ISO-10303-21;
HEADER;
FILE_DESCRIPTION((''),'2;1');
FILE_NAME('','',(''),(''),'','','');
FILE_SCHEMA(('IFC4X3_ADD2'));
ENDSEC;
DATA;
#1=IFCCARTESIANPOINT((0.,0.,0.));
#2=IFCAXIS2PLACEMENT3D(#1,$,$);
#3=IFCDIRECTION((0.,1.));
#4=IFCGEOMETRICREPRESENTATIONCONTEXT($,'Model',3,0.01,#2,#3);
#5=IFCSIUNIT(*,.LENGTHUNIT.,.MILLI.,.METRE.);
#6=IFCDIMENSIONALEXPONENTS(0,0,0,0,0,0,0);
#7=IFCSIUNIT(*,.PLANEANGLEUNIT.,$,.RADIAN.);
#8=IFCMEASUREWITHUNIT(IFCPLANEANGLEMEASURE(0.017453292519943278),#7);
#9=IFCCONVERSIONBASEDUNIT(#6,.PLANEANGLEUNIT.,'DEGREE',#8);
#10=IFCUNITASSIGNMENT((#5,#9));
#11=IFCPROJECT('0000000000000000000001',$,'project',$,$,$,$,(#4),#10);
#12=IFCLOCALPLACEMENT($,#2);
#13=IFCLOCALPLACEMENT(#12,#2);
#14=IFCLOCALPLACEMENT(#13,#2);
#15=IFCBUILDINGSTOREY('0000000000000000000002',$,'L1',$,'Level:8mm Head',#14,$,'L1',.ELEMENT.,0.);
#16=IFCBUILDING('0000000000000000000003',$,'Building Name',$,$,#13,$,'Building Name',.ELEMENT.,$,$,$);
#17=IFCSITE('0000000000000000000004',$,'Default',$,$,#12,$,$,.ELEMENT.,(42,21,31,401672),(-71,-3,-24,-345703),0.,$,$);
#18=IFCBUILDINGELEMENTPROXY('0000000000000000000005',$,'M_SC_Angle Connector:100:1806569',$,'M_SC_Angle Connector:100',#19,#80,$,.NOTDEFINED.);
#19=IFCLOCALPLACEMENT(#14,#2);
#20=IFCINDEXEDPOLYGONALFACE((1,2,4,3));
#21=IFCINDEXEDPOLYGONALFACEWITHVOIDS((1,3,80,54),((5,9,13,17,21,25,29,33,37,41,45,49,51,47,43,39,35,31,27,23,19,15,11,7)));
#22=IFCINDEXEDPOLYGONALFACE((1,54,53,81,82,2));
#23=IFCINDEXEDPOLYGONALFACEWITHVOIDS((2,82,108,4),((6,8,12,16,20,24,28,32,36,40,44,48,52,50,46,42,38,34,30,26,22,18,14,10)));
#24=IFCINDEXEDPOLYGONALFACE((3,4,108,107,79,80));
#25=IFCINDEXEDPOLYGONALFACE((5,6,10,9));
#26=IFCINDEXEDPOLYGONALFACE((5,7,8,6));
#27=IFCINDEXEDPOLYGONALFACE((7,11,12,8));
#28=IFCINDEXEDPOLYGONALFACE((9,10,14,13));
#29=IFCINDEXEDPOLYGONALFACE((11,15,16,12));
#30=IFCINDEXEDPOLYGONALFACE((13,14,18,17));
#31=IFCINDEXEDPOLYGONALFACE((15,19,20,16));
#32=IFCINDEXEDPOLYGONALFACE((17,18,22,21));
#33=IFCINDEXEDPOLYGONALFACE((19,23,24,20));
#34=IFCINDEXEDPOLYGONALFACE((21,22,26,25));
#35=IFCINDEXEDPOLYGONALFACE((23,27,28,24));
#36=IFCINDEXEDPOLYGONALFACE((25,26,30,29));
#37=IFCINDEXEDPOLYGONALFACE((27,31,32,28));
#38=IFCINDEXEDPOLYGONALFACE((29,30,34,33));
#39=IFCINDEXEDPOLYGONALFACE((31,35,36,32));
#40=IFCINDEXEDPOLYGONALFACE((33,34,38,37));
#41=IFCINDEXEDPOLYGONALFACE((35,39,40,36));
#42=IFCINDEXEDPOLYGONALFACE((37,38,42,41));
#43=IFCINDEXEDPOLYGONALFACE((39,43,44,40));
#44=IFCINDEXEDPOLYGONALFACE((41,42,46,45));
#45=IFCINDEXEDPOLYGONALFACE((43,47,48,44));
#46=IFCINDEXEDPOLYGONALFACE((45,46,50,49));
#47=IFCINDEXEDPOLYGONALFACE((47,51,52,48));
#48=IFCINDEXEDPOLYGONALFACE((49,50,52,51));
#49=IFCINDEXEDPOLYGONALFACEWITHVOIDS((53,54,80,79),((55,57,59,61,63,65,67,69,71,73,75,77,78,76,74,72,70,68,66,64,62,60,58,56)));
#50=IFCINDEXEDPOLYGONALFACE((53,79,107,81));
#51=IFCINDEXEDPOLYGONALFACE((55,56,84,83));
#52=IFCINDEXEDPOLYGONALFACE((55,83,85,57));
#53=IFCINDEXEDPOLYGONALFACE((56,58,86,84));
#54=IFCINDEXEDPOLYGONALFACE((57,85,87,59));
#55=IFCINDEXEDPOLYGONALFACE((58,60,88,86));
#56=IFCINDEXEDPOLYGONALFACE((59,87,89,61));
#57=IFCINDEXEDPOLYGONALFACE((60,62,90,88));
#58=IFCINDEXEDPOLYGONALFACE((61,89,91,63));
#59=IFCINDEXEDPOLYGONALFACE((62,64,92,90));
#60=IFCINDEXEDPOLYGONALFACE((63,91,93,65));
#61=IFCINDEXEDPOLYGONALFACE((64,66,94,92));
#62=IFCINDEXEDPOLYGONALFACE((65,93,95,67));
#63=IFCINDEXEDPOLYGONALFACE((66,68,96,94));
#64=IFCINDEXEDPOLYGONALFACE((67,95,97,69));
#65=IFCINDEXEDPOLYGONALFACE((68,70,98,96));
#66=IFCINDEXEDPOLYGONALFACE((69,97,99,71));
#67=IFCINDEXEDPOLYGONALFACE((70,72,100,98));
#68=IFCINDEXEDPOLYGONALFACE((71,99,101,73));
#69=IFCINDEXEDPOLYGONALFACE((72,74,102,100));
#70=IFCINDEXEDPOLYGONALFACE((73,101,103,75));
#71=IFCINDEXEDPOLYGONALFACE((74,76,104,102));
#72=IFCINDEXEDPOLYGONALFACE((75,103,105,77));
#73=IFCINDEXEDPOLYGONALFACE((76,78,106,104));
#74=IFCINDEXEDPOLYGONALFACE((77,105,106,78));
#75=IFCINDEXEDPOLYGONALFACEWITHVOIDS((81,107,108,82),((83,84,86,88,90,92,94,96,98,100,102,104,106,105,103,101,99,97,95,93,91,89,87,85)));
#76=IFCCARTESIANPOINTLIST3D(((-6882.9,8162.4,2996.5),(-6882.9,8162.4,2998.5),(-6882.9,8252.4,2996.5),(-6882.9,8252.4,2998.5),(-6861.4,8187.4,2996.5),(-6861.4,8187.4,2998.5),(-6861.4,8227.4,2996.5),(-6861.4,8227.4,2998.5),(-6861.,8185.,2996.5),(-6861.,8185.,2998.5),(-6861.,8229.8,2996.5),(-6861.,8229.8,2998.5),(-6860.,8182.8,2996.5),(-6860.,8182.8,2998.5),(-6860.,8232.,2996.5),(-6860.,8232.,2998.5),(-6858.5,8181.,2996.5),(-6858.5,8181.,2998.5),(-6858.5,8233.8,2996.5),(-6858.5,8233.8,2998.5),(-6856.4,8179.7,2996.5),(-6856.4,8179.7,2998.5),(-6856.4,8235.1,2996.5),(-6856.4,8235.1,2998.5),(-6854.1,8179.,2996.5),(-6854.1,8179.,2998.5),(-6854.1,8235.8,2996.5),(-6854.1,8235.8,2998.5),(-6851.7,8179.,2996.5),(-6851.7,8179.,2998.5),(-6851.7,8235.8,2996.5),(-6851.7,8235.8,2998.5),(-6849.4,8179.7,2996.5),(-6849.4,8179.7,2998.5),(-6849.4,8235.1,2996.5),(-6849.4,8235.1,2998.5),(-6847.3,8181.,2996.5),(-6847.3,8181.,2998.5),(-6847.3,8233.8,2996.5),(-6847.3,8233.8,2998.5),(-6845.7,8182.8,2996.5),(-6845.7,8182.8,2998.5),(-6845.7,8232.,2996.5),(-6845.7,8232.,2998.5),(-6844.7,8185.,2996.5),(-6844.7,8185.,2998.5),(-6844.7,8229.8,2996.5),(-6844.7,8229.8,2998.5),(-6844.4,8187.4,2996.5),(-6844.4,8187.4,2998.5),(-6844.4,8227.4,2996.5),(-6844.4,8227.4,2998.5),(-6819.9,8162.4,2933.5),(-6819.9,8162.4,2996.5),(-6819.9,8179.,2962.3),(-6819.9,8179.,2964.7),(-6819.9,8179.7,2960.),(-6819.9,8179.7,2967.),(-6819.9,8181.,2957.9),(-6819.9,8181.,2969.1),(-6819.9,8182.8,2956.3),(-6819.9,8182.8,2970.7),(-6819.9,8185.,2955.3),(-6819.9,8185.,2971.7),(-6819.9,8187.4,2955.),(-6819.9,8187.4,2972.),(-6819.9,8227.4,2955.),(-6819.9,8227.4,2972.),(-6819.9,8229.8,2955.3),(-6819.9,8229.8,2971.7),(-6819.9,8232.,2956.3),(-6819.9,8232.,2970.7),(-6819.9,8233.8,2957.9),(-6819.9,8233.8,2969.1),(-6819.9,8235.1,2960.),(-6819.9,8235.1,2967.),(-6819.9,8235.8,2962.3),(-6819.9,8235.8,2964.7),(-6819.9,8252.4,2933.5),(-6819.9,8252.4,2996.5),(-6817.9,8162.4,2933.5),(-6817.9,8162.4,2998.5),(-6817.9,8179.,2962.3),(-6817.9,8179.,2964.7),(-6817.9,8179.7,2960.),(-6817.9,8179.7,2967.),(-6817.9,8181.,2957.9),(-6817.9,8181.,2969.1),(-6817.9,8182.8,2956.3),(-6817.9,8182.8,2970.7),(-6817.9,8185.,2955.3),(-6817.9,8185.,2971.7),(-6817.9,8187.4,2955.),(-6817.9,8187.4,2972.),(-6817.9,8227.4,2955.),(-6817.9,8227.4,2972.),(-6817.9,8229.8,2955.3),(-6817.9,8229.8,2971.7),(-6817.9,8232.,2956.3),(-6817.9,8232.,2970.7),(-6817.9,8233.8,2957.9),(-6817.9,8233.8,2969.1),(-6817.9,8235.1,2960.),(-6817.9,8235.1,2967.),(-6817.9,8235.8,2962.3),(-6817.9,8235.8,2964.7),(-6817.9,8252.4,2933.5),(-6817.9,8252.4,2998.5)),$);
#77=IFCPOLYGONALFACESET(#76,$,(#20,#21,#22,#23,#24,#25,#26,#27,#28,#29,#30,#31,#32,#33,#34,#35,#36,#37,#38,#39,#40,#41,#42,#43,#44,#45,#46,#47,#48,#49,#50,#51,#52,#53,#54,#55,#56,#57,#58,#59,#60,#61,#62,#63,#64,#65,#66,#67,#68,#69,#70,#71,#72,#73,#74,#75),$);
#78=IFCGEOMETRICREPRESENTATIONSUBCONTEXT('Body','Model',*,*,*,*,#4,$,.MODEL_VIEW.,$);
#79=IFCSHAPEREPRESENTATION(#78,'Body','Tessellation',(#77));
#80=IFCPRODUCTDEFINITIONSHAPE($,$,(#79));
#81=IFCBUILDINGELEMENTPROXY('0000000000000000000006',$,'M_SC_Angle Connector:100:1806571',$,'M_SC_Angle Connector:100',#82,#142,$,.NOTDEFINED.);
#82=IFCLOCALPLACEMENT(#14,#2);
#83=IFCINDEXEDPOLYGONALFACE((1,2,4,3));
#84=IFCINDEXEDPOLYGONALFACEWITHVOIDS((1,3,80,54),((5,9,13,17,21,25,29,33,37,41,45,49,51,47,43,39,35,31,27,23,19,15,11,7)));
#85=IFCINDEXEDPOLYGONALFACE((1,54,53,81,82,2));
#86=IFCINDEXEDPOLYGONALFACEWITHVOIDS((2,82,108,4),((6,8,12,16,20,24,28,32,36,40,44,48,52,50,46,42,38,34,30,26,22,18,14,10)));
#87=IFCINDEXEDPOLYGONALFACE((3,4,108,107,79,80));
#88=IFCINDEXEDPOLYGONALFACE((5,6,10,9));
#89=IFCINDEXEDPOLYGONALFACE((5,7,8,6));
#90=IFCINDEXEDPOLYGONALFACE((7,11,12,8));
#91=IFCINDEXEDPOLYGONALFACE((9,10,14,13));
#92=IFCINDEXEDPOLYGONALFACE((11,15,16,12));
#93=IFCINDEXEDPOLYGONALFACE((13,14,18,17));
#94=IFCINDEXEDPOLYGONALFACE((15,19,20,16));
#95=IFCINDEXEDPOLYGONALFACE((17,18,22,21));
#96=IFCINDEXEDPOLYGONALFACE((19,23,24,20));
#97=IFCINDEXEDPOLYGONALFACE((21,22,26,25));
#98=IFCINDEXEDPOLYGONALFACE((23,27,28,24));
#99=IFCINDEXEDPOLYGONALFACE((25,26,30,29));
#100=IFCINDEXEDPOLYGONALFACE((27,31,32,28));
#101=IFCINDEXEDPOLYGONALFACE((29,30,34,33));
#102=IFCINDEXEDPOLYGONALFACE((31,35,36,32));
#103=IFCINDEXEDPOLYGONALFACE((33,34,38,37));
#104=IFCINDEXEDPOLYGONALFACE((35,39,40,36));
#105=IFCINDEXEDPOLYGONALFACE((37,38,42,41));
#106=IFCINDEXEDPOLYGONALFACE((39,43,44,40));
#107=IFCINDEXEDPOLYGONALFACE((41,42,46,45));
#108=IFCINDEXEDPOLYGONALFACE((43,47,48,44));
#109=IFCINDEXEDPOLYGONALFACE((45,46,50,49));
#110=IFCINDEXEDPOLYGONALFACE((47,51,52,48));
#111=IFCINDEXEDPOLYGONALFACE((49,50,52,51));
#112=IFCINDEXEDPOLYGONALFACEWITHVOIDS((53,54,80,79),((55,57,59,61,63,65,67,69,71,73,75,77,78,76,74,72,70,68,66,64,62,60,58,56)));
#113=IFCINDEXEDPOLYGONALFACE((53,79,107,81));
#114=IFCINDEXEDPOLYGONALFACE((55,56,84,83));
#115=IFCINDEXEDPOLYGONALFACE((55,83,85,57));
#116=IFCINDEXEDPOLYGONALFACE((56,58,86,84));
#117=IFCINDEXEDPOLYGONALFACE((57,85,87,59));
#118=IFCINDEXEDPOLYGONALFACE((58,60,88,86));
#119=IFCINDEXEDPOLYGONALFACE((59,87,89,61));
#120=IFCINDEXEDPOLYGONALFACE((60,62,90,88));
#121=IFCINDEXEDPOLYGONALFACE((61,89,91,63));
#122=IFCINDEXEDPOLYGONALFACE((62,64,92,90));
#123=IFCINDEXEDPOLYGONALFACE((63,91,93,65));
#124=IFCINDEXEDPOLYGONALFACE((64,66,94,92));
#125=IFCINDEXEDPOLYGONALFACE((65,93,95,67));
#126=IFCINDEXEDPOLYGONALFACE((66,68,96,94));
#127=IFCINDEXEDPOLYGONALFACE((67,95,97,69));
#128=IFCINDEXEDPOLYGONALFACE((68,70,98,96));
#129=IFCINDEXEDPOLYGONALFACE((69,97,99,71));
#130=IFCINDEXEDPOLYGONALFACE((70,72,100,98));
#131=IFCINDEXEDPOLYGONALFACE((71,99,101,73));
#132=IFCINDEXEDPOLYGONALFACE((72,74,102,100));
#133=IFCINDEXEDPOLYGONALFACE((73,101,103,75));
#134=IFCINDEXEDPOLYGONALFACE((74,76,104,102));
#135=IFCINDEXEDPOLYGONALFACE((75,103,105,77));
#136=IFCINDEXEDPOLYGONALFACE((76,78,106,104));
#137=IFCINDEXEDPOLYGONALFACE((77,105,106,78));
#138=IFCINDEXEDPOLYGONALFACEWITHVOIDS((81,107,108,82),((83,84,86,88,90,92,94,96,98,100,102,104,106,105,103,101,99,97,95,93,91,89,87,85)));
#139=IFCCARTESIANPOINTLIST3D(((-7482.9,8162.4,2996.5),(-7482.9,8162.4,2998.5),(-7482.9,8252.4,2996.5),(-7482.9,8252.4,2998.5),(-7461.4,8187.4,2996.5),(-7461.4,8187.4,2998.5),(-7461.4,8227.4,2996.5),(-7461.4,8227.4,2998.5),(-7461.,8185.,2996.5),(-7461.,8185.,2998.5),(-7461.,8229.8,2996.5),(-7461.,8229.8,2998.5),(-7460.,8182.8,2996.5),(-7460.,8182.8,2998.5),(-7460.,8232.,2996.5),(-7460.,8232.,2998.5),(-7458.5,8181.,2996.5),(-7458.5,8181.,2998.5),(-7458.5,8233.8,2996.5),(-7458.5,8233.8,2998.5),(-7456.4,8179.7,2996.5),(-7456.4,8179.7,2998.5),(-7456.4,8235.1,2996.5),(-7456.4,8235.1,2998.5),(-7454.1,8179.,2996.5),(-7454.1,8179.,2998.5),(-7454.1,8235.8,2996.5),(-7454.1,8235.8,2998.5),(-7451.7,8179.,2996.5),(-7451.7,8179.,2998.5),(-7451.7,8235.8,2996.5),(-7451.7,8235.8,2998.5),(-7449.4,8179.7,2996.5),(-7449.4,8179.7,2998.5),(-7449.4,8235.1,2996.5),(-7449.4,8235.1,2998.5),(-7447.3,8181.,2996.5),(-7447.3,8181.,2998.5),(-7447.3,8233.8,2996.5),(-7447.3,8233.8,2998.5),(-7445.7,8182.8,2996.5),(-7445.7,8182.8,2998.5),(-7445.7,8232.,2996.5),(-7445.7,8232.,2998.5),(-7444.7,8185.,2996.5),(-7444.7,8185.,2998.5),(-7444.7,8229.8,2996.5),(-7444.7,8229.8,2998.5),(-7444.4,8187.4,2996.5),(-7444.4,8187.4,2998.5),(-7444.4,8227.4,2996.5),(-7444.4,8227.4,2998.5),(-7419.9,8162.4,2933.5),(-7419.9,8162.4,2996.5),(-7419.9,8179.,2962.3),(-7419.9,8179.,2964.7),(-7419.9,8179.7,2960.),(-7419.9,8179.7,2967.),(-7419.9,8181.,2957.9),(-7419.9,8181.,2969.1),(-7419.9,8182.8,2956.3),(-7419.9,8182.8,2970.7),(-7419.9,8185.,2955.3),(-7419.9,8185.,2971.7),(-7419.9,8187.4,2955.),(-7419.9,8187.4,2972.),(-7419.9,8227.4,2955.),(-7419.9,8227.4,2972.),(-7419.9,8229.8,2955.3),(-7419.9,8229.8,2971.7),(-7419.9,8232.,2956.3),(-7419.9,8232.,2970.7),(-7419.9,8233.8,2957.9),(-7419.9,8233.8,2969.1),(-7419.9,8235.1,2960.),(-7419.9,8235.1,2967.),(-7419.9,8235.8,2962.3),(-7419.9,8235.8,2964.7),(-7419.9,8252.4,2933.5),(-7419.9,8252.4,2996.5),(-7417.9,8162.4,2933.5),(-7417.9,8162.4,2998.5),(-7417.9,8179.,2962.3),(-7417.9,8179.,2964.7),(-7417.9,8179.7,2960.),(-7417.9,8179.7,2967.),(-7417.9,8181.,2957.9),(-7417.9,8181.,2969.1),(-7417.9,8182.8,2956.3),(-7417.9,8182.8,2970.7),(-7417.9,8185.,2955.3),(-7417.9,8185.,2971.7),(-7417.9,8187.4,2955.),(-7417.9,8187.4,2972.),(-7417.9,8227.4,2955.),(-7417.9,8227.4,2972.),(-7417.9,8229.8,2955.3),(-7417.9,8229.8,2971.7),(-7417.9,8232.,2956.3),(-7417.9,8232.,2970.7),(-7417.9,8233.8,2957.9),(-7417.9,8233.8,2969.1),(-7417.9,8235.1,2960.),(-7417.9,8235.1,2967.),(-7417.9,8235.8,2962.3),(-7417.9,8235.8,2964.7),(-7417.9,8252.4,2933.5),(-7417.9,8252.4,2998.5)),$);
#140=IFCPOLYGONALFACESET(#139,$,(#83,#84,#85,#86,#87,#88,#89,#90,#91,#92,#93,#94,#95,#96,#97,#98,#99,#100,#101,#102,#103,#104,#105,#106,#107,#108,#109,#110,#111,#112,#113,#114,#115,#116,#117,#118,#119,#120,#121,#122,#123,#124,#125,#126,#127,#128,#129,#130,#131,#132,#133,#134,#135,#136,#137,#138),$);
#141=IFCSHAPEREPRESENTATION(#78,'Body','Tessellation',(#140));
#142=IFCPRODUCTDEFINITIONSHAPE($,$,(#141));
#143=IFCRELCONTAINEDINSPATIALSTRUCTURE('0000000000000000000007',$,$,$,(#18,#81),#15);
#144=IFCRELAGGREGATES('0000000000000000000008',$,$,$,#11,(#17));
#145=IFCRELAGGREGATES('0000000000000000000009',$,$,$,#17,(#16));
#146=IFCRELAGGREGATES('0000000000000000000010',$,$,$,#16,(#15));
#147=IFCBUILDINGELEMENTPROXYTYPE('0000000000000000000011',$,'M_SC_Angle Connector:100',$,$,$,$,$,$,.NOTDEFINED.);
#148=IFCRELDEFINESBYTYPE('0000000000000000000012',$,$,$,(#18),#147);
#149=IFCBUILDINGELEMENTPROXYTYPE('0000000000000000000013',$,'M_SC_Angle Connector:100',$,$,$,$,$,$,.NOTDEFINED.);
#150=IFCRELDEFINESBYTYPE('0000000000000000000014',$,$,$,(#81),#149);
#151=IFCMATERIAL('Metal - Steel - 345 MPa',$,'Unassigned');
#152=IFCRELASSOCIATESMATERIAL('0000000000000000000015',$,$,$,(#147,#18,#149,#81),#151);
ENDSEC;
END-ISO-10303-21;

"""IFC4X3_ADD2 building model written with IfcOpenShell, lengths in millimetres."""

from ifc_helpers import new_model, entity, si_unit, converted_unit, direction, frame, frame_2d, origin, place, context, subcontext, project, spatial, polyline, circle_curve, parameter, trimmed, segment, composite_curve, outline, extrude, source, transform, mapped, material, type_object, type_shapes, element, save


model = new_model("IFC4X3_ADD2")

# Units and contexts
model_context = context("Model", 3, precision=0.01, world=origin(), true_north=direction((0.0, 1.0)))
body_context = subcontext(model_context, "Body", "Model", "MODEL_VIEW")
ifc_project = project(units=[si_unit("LENGTHUNIT", "METRE", prefix="MILLI"), converted_unit("PLANEANGLEUNIT", "DEGREE", entity("IfcPlaneAngleMeasure", 0.017453292519943278), si_unit("PLANEANGLEUNIT", "RADIAN"), dimensions=[0, 0, 0, 0, 0, 0, 0])], contexts=[model_context])

# Site, building, storey
site_placement = place(None, origin())
site = spatial("IfcSite", under=ifc_project, at=site_placement, Name="Default", CompositionType="ELEMENT", RefLatitude=(42, 21, 31, 401672), RefLongitude=(-71, -3, -24, -345703), RefElevation=0.0)
building_placement = place(site_placement, origin())
building = spatial("IfcBuilding", under=site, at=building_placement, Name="Building Name", LongName="Building Name", CompositionType="ELEMENT")
storey_placement = place(building_placement, origin())
storey = spatial("IfcBuildingStorey", under=building, at=storey_placement, Name="L1", ObjectType="Level:8mm Head", LongName="L1", CompositionType="ELEMENT", Elevation=0.0)

# Building element proxies, openings
ifc_material_1 = material(Name="Metal - Steel - 345 MPa", Category="Unassigned")
building_element_proxy_type_1 = type_object("IfcBuildingElementProxyType", Name="M_SC_Angle Connector:100", PredefinedType="NOTDEFINED", material=ifc_material_1)
shared_shape_1 = source(origin(), body_context, "Body", "SweptSolid", [
    extrude(outline(polyline([(-42.7, -22.3), (22.3, -22.3), (22.3, 42.7), (20.3, 42.7), (20.3, -20.3), (-42.7, -20.3), (-42.7, -22.3)])), frame((22.3, -45.0, 22.3), z_axis=(0.0, 1.0, 0.0), x_axis=(-1.0, 0.0, 0.0)), (0.0, 0.0, 1.0), 90.0),
])
type_shapes(building_element_proxy_type_1, [shared_shape_1])
proxy_1_placement = place(storey_placement, frame((-6817.9, 8207.4, 2998.5), z_axis=(0.0, 0.0, -1.0), x_axis=(-1.0, 0.0, 0.0)))
proxy_1 = element("IfcBuildingElementProxy", 1, at=proxy_1_placement, inside=storey, type_object=building_element_proxy_type_1, material=ifc_material_1, Name="M_SC_Angle Connector:100:1806569", ObjectType="M_SC_Angle Connector:100", PredefinedType="NOTDEFINED", context=body_context, shape_type="MappedRepresentation", body=[
    mapped(shared_shape_1, transform((0.0, 0.0, 0.0), scale=1.0)),
])
opening_1_placement = place(storey_placement, frame((-6817.9, 8207.4, 2998.5)))
element("IfcOpeningElement", 2, at=opening_1_placement, cuts=proxy_1, PredefinedType="OPENING", context=body_context, shape_type="SweptSolid", body=[
    extrude(outline(composite_curve([segment(trimmed(circle_curve(frame_2d((0.0, -20.0), x_axis=(1.0, 0.0)), 8.5), [parameter(180.0)], [parameter(0.0)], True, "PARAMETER"), True, "CONTINUOUS"), segment(polyline([(8.5, -20.0), (8.5, 20.0)]), True, "CONTINUOUS"), segment(trimmed(circle_curve(frame_2d((0.0, 20.0), x_axis=(1.0, 0.0)), 8.5), [parameter(0.0)], [parameter(180.0)], True, "PARAMETER"), True, "CONTINUOUS"), segment(polyline([(-8.5, 20.0), (-8.5, -20.0)]), True, "CONTINUOUS")], self_intersect=False)), frame((-2.0, 0.0, -35.0), z_axis=(1.0, 0.0, 0.0), x_axis=(0.0, 0.0, -1.0)), (0.0, 0.0, 1.0), 2.0),
])
opening_2_placement = place(storey_placement, frame((-6817.9, 8207.4, 2998.5)))
element("IfcOpeningElement", 3, at=opening_2_placement, cuts=proxy_1, PredefinedType="OPENING", context=body_context, shape_type="SweptSolid", body=[
    extrude(outline(composite_curve([segment(trimmed(circle_curve(frame_2d((0.0, 20.0), x_axis=(1.0, 0.0)), 8.5), [parameter(0.0)], [parameter(180.0)], True, "PARAMETER"), True, "CONTINUOUS"), segment(polyline([(-8.5, 20.0), (-8.5, -20.0)]), True, "CONTINUOUS"), segment(trimmed(circle_curve(frame_2d((0.0, -20.0), x_axis=(1.0, 0.0)), 8.5), [parameter(180.0)], [parameter(0.0)], True, "PARAMETER"), True, "CONTINUOUS"), segment(polyline([(8.5, -20.0), (8.5, 20.0)]), True, "CONTINUOUS")], self_intersect=False)), frame((-35.0, 0.0, -2.0), z_axis=(0.0, 0.0, 1.0), x_axis=(-1.0, 0.0, 0.0)), (0.0, 0.0, 1.0), 2.0),
])
building_element_proxy_type_2 = type_object("IfcBuildingElementProxyType", Name="M_SC_Angle Connector:100", PredefinedType="NOTDEFINED", material=ifc_material_1)
shared_shape_2 = source(origin(), body_context, "Body", "SweptSolid", [
    extrude(outline(polyline([(-42.7, -22.3), (22.3, -22.3), (22.3, 42.7), (20.3, 42.7), (20.3, -20.3), (-42.7, -20.3), (-42.7, -22.3)])), frame((22.3, -45.0, 22.3), z_axis=(0.0, 1.0, 0.0), x_axis=(-1.0, 0.0, 0.0)), (0.0, 0.0, 1.0), 90.0),
])
type_shapes(building_element_proxy_type_2, [shared_shape_2])
proxy_2_placement = place(storey_placement, frame((-7417.9, 8207.4, 2998.5), z_axis=(0.0, 0.0, -1.0), x_axis=(-1.0, 0.0, 0.0)))
proxy_2 = element("IfcBuildingElementProxy", 4, at=proxy_2_placement, inside=storey, type_object=building_element_proxy_type_2, material=ifc_material_1, Name="M_SC_Angle Connector:100:1806571", ObjectType="M_SC_Angle Connector:100", PredefinedType="NOTDEFINED", context=body_context, shape_type="MappedRepresentation", body=[
    mapped(shared_shape_2, transform((0.0, 0.0, 0.0), scale=1.0)),
])
opening_3_placement = place(storey_placement, frame((-7417.9, 8207.4, 2998.5)))
element("IfcOpeningElement", 5, at=opening_3_placement, cuts=proxy_2, PredefinedType="OPENING", context=body_context, shape_type="SweptSolid", body=[
    extrude(outline(composite_curve([segment(trimmed(circle_curve(frame_2d((0.0, -20.0), x_axis=(1.0, 0.0)), 8.5), [parameter(180.0)], [parameter(0.0)], True, "PARAMETER"), True, "CONTINUOUS"), segment(polyline([(8.5, -20.0), (8.5, 20.0)]), True, "CONTINUOUS"), segment(trimmed(circle_curve(frame_2d((0.0, 20.0), x_axis=(1.0, 0.0)), 8.5), [parameter(0.0)], [parameter(180.0)], True, "PARAMETER"), True, "CONTINUOUS"), segment(polyline([(-8.5, 20.0), (-8.5, -20.0)]), True, "CONTINUOUS")], self_intersect=False)), frame((-2.0, 0.0, -35.0), z_axis=(1.0, 0.0, 0.0), x_axis=(0.0, 0.0, -1.0)), (0.0, 0.0, 1.0), 2.0),
])
opening_4_placement = place(storey_placement, frame((-7417.9, 8207.4, 2998.5)))
element("IfcOpeningElement", 6, at=opening_4_placement, cuts=proxy_2, PredefinedType="OPENING", context=body_context, shape_type="SweptSolid", body=[
    extrude(outline(composite_curve([segment(trimmed(circle_curve(frame_2d((0.0, 20.0), x_axis=(1.0, 0.0)), 8.5), [parameter(0.0)], [parameter(180.0)], True, "PARAMETER"), True, "CONTINUOUS"), segment(polyline([(-8.5, 20.0), (-8.5, -20.0)]), True, "CONTINUOUS"), segment(trimmed(circle_curve(frame_2d((0.0, -20.0), x_axis=(1.0, 0.0)), 8.5), [parameter(180.0)], [parameter(0.0)], True, "PARAMETER"), True, "CONTINUOUS"), segment(polyline([(8.5, -20.0), (8.5, 20.0)]), True, "CONTINUOUS")], self_intersect=False)), frame((-35.0, 0.0, -2.0), z_axis=(0.0, 0.0, 1.0), x_axis=(-1.0, 0.0, 0.0)), (0.0, 0.0, 1.0), 2.0),
])

save(model, "model.ifc")
